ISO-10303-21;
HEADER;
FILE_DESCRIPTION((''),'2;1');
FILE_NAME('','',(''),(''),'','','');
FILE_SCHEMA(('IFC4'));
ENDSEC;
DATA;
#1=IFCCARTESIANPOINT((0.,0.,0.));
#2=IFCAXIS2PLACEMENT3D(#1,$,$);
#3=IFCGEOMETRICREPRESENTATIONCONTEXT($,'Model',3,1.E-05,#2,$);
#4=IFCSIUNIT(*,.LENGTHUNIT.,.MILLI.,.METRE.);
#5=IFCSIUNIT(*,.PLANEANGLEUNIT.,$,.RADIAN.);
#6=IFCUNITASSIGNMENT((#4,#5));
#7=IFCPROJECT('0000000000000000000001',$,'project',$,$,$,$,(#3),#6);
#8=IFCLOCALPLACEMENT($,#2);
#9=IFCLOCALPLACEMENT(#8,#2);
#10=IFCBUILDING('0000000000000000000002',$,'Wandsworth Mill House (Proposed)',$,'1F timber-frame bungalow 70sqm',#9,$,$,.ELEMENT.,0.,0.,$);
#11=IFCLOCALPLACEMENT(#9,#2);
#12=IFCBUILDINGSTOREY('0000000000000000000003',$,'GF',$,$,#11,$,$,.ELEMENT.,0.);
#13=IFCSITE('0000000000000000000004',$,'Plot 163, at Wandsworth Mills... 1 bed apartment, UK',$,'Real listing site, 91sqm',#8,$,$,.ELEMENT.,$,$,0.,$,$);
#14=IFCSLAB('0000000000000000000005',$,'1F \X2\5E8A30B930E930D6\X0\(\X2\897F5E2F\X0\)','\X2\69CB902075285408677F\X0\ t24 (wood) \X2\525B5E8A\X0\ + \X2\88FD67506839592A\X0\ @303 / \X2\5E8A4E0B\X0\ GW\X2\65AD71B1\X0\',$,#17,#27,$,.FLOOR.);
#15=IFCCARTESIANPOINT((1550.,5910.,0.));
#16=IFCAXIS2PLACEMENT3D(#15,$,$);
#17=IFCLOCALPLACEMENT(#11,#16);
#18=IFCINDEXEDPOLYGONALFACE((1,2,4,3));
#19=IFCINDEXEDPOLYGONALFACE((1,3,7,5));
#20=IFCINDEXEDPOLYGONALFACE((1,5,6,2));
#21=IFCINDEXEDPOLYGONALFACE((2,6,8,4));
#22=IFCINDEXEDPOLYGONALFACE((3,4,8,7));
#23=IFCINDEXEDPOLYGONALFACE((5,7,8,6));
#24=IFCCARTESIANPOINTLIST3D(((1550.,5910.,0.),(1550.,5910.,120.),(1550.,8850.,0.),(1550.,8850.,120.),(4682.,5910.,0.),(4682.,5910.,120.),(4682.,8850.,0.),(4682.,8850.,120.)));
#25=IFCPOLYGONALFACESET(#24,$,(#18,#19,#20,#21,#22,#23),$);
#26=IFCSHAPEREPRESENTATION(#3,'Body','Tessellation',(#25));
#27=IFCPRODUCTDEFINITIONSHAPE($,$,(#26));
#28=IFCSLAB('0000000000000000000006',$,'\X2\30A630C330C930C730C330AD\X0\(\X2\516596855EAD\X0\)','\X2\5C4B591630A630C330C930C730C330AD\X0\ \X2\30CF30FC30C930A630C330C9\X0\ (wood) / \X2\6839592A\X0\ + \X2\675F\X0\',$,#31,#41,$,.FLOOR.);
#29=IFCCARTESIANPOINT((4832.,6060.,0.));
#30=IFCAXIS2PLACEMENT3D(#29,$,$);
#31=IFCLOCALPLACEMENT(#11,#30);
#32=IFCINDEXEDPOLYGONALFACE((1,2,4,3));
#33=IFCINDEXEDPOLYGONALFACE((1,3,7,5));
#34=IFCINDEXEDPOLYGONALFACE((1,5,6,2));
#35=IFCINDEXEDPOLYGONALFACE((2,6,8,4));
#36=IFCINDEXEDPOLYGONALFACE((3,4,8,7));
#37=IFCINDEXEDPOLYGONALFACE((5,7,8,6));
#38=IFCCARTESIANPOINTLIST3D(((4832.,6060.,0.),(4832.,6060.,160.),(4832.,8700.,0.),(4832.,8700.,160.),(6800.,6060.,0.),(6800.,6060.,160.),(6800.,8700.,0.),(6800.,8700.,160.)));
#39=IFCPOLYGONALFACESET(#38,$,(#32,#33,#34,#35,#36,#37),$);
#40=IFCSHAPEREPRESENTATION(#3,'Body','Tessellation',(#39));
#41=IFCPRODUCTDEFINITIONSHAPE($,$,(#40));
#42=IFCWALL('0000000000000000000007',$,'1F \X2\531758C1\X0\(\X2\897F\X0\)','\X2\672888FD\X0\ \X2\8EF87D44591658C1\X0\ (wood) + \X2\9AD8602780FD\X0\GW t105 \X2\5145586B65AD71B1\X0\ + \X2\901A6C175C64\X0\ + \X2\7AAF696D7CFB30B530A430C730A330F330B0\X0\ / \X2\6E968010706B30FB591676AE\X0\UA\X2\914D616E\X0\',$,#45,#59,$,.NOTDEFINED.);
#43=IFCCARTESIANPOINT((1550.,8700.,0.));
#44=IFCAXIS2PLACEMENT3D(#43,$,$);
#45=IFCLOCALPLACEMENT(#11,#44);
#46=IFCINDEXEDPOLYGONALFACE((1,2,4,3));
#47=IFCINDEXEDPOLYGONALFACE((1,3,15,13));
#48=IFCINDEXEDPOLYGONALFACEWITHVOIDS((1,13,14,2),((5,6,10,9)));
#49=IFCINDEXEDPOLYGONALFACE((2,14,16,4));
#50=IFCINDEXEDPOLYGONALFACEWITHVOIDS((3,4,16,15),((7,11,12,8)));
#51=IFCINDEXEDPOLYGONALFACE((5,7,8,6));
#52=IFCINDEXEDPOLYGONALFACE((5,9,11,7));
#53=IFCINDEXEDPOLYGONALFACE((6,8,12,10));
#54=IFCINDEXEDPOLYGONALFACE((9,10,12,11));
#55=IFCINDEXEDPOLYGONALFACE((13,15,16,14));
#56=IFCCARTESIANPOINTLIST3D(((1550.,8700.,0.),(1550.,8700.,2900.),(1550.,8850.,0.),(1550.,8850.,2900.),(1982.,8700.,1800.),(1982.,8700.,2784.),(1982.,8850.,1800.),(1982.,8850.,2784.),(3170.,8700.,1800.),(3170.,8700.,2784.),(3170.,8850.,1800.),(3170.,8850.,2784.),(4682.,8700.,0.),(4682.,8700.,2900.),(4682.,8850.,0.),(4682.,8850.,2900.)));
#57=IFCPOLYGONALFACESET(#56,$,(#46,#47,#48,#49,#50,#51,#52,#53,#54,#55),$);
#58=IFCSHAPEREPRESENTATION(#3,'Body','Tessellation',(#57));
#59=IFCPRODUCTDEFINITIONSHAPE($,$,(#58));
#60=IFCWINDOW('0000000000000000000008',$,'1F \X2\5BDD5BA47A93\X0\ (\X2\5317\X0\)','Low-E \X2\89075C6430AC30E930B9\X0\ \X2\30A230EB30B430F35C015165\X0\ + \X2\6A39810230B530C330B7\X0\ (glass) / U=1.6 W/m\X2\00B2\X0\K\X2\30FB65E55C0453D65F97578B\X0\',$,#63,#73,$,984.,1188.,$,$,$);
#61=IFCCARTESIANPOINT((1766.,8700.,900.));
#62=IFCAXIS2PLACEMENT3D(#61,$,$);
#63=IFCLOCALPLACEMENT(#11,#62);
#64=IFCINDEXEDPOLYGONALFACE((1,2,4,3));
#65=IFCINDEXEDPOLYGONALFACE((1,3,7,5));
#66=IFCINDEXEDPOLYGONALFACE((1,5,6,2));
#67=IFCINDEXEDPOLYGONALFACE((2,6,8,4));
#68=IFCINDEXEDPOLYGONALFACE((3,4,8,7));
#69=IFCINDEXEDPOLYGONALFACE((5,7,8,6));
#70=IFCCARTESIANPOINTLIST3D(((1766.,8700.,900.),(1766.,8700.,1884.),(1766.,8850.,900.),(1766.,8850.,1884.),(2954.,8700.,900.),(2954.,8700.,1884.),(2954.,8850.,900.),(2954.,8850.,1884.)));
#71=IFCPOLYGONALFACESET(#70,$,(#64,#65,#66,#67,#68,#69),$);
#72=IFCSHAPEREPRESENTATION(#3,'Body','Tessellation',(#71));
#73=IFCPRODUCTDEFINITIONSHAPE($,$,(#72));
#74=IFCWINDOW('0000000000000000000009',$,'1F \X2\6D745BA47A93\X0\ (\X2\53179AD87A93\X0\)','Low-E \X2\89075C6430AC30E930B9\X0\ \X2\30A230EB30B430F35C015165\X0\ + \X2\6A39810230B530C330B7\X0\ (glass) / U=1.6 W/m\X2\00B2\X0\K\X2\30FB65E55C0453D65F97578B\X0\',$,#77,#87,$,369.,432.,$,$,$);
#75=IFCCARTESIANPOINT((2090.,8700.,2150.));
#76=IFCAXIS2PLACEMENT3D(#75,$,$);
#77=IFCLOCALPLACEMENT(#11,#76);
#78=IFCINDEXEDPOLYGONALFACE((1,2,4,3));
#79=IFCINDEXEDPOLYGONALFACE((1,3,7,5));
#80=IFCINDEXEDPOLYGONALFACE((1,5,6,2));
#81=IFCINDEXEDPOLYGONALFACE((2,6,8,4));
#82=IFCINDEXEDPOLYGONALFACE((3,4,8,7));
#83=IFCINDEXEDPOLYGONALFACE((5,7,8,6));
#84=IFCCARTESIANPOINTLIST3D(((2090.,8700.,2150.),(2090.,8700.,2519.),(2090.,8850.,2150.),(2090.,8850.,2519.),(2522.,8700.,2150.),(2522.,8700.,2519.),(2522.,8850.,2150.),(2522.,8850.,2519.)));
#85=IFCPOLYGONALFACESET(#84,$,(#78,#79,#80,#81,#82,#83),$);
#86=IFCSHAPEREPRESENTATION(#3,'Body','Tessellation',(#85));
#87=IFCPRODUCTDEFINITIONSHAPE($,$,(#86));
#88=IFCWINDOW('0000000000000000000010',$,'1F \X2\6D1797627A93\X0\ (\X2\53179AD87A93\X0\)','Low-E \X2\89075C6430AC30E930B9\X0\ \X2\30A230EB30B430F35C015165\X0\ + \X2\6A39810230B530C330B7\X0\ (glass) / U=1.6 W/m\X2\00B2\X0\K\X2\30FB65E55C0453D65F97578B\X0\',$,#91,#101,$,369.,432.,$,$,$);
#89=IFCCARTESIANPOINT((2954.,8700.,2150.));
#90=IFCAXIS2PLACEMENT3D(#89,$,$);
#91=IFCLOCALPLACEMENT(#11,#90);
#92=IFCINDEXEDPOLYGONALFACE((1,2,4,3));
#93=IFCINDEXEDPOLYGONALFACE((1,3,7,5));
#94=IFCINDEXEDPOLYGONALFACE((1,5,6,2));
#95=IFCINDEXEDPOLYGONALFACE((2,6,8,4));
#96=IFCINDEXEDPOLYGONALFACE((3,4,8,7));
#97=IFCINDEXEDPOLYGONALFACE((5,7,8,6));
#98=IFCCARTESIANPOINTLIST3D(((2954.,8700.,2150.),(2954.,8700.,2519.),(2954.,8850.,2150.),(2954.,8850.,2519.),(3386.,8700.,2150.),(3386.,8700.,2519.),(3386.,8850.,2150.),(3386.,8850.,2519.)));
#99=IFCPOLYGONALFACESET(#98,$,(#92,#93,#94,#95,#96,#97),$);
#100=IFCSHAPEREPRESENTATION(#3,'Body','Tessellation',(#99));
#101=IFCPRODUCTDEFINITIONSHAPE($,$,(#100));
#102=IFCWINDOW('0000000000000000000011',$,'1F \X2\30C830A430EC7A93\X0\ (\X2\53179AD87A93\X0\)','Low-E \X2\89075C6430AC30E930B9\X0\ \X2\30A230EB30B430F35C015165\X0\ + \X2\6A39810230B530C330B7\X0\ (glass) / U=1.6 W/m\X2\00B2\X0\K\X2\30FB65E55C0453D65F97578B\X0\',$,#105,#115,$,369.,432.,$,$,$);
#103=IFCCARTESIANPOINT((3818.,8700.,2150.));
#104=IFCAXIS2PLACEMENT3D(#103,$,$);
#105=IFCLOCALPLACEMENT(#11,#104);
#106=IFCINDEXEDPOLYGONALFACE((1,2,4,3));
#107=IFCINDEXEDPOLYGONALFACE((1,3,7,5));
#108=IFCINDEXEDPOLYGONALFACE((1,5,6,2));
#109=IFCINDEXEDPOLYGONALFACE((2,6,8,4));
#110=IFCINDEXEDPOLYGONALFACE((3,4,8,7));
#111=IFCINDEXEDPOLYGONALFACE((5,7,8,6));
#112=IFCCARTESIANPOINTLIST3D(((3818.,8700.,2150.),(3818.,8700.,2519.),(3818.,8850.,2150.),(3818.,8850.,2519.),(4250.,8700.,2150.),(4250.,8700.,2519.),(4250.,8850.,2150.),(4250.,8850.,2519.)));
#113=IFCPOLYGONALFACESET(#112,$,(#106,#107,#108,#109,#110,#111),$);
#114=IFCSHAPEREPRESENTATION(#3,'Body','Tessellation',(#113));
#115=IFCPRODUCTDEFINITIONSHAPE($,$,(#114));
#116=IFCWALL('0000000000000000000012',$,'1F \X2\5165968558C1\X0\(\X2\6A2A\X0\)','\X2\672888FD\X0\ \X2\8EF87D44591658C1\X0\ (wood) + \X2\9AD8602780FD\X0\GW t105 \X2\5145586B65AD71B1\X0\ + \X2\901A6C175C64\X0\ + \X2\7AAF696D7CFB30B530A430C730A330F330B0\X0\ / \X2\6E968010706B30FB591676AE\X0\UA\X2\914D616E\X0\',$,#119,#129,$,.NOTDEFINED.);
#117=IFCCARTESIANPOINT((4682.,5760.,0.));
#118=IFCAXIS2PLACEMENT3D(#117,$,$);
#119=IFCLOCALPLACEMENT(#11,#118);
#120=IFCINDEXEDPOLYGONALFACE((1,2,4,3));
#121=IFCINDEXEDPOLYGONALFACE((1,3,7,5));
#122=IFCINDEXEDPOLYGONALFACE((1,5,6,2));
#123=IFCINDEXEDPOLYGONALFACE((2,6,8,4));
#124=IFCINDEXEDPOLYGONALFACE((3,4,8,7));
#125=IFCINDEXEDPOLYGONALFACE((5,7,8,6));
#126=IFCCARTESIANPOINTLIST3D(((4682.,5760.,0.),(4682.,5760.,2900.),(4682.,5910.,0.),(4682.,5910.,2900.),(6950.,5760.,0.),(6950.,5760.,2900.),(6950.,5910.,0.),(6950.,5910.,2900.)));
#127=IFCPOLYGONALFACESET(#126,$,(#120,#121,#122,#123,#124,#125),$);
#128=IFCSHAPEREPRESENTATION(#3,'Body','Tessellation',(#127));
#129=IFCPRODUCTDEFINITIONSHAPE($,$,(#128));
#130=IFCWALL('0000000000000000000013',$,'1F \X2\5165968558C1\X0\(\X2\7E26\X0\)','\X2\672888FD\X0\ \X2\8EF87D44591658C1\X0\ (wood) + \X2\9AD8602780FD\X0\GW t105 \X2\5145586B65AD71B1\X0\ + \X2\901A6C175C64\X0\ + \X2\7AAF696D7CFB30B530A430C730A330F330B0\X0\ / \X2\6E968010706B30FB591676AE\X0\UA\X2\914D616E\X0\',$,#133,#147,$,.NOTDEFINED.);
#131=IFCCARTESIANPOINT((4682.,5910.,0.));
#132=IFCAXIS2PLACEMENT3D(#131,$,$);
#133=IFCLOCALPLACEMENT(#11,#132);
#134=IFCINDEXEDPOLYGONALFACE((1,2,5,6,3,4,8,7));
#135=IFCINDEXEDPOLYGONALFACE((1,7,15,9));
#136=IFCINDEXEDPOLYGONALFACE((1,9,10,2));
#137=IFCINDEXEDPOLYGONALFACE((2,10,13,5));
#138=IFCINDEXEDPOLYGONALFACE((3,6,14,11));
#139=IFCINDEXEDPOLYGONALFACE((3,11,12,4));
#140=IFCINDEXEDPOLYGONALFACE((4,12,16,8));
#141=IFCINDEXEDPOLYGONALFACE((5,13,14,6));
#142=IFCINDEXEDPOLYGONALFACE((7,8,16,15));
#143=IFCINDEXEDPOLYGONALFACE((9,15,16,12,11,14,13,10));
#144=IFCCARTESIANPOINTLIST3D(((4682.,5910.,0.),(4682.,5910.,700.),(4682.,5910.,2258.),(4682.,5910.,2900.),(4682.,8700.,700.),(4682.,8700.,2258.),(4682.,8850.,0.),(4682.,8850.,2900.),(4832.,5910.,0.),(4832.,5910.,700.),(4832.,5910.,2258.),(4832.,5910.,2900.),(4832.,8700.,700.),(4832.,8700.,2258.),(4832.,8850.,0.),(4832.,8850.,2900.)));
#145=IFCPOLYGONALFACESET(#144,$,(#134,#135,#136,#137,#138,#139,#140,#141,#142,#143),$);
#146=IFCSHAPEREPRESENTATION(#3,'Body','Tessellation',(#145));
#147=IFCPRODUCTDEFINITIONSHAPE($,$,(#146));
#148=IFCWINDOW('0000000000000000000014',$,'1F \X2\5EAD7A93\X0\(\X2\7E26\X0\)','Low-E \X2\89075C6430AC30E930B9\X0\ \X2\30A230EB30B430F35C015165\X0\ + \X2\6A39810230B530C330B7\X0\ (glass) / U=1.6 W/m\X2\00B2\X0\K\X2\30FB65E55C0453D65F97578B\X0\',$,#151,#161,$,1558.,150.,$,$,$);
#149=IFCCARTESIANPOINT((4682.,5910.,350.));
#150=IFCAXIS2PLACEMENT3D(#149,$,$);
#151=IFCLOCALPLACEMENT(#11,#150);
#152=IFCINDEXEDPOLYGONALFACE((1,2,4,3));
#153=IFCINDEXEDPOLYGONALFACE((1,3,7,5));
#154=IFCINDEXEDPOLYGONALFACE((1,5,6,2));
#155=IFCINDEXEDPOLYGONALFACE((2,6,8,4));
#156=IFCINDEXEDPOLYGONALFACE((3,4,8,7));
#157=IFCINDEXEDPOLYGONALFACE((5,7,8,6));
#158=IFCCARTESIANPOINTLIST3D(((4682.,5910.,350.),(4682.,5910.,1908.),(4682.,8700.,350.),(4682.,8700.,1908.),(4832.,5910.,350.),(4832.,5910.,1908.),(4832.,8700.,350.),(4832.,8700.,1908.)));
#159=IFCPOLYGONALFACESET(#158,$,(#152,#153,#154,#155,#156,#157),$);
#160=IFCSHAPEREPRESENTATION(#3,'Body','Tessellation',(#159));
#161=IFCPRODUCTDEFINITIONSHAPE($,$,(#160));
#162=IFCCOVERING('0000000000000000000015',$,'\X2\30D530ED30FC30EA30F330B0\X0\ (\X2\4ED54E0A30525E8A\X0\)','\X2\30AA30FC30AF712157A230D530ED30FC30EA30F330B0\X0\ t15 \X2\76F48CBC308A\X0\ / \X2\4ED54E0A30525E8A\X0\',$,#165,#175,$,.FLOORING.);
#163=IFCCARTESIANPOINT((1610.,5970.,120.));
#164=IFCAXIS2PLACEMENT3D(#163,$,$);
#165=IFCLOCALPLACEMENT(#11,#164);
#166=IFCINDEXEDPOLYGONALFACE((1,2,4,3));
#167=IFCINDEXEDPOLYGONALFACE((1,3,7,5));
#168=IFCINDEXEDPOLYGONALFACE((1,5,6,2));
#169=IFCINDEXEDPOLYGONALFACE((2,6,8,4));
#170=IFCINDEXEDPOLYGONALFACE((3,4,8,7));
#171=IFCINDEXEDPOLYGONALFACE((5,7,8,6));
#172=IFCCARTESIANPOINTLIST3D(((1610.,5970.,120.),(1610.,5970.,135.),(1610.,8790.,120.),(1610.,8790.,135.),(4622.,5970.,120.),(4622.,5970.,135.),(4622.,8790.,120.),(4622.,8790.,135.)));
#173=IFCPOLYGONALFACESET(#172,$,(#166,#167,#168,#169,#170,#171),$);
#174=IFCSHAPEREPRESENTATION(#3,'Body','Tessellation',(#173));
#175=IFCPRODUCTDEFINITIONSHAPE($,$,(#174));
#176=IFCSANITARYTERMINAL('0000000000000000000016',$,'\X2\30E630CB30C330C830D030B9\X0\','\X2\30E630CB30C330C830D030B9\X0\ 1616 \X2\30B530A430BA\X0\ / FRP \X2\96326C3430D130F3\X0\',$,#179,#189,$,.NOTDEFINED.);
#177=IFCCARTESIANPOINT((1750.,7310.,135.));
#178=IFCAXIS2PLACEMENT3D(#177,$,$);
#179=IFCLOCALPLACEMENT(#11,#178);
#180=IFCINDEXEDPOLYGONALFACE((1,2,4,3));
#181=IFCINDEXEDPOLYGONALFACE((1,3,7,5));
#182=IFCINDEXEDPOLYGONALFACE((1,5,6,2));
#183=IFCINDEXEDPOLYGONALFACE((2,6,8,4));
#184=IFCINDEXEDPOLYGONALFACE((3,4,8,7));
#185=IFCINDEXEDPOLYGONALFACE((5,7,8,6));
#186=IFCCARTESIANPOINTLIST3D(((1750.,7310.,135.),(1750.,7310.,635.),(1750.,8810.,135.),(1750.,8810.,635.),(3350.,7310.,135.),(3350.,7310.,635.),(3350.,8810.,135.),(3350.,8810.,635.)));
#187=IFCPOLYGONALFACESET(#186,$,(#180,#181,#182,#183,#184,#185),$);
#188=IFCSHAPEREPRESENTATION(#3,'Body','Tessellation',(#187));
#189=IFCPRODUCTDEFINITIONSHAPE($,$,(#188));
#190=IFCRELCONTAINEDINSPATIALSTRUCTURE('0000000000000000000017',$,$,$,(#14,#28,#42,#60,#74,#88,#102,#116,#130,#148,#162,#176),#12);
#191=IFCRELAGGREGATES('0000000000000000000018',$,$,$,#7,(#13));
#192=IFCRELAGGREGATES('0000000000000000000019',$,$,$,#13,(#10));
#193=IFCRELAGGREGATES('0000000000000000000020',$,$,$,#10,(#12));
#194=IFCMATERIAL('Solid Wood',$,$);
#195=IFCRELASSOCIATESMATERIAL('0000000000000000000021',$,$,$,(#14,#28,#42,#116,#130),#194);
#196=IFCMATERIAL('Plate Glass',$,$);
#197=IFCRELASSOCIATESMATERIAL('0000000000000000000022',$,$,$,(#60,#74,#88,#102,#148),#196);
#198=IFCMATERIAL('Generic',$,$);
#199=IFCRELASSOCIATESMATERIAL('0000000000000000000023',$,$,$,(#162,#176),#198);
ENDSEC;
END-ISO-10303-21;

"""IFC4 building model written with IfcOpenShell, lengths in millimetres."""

from ifc_helpers import new_model, si_unit, frame, frame_2d, origin, place, context, project, spatial, rectangle, extrude, material, element, fill, save


model = new_model("IFC4")

# Units and contexts
model_context = context("Model", 3, precision=1e-05, world=origin())
ifc_project = project(units=[si_unit("LENGTHUNIT", "METRE", prefix="MILLI"), si_unit("PLANEANGLEUNIT", "RADIAN")], contexts=[model_context])

# Site, building, storey
site_placement = place(None, origin())
site = spatial("IfcSite", under=ifc_project, at=site_placement, Name="Plot 163, at Wandsworth Mills... 1 bed apartment, UK", ObjectType="Real listing site, 91sqm", CompositionType="ELEMENT", RefElevation=0.0)
building_placement = place(site_placement, origin())
building = spatial("IfcBuilding", under=site, at=building_placement, Name="Wandsworth Mill House (Proposed)", ObjectType="1F timber-frame bungalow 70sqm", CompositionType="ELEMENT", ElevationOfRefHeight=0.0, ElevationOfTerrain=0.0)
storey_placement = place(building_placement, origin())
storey = spatial("IfcBuildingStorey", under=building, at=storey_placement, Name="GF", CompositionType="ELEMENT", Elevation=0.0)

# Slabs
ifc_material_1 = material(Name="Solid Wood")
slab_1_placement = place(storey_placement, frame((1550.0, 5910.0, 0.0)))
element("IfcSlab", 1, at=slab_1_placement, inside=storey, material=ifc_material_1, Name="1F 床スラブ(西帯)", Description="構造用合板 t24 (wood) 剛床 + 製材根太 @303 / 床下 GW断熱", PredefinedType="FLOOR", context=model_context, shape_type="SweptSolid", body=[
    extrude(rectangle(XDim=3132.0, YDim=2940.0, at=frame_2d((1566.0, 1470.0))), frame((1550.0, 5910.0, 0.0)), (0.0, 0.0, 1.0), 120.0),
])
slab_2_placement = place(storey_placement, frame((4832.0, 6060.0, 0.0)))
element("IfcSlab", 2, at=slab_2_placement, inside=storey, material=ifc_material_1, Name="ウッドデッキ(入隅庭)", Description="屋外ウッドデッキ ハードウッド (wood) / 根太 + 束", PredefinedType="FLOOR", context=model_context, shape_type="SweptSolid", body=[
    extrude(rectangle(XDim=1968.0, YDim=2640.0, at=frame_2d((984.0, 1320.0))), frame((4832.0, 6060.0, 0.0)), (0.0, 0.0, 1.0), 160.0),
])

# Wall, openings, windows
wall_1_placement = place(storey_placement, frame((1550.0, 8700.0, 0.0)))
wall_1 = element("IfcWall", 3, at=wall_1_placement, inside=storey, material=ifc_material_1, Name="1F 北壁(西)", Description="木製 軸組外壁 (wood) + 高性能GW t105 充填断熱 + 通気層 + 窯業系サイディング / 準耐火・外皮UA配慮", PredefinedType="NOTDEFINED", context=model_context, shape_type="SweptSolid", body=[
    extrude(rectangle(XDim=3132.0, YDim=150.0, at=frame_2d((1566.0, 75.0))), frame((1550.0, 8700.0, 0.0)), (0.0, 0.0, 1.0), 2900.0),
])
opening_1_placement = place(storey_placement, frame((1766.0, 8700.0, 900.0)))
opening_1 = element("IfcOpeningElement", 4, at=opening_1_placement, cuts=wall_1, PredefinedType="NOTDEFINED", context=model_context, shape_type="SweptSolid", body=[
    extrude(rectangle(XDim=1188.0, YDim=150.0, at=frame_2d((594.0, 75.0))), frame((1766.0, 8700.0, 900.0)), (0.0, 0.0, 1.0), 984.0),
])
opening_2_placement = place(storey_placement, frame((2090.0, 8700.0, 2150.0)))
opening_2 = element("IfcOpeningElement", 5, at=opening_2_placement, cuts=wall_1, PredefinedType="NOTDEFINED", context=model_context, shape_type="SweptSolid", body=[
    extrude(rectangle(XDim=432.0, YDim=150.0, at=frame_2d((216.0, 75.0))), frame((2090.0, 8700.0, 2150.0)), (0.0, 0.0, 1.0), 369.0),
])
opening_3_placement = place(storey_placement, frame((2954.0, 8700.0, 2150.0)))
opening_3 = element("IfcOpeningElement", 6, at=opening_3_placement, cuts=wall_1, PredefinedType="NOTDEFINED", context=model_context, shape_type="SweptSolid", body=[
    extrude(rectangle(XDim=432.0, YDim=150.0, at=frame_2d((216.0, 75.0))), frame((2954.0, 8700.0, 2150.0)), (0.0, 0.0, 1.0), 369.0),
])
opening_4_placement = place(storey_placement, frame((3818.0, 8700.0, 2150.0)))
opening_4 = element("IfcOpeningElement", 7, at=opening_4_placement, cuts=wall_1, PredefinedType="NOTDEFINED", context=model_context, shape_type="SweptSolid", body=[
    extrude(rectangle(XDim=432.0, YDim=150.0, at=frame_2d((216.0, 75.0))), frame((3818.0, 8700.0, 2150.0)), (0.0, 0.0, 1.0), 369.0),
])
ifc_material_2 = material(Name="Plate Glass")
window_1_placement = place(storey_placement, frame((1766.0, 8700.0, 900.0)))
window_1 = element("IfcWindow", 8, at=window_1_placement, inside=storey, material=ifc_material_2, Name="1F 寝室窓 (北)", Description="Low-E 複層ガラス アルゴン封入 + 樹脂サッシ (glass) / U=1.6 W/m²K・日射取得型", OverallHeight=984.0, OverallWidth=1188.0, context=model_context, shape_type="SweptSolid", body=[
    extrude(rectangle(XDim=1188.0, YDim=150.0, at=frame_2d((594.0, 75.0))), frame((1766.0, 8700.0, 900.0)), (0.0, 0.0, 1.0), 984.0),
])
fill(opening_1, window_1)
window_2_placement = place(storey_placement, frame((2090.0, 8700.0, 2150.0)))
window_2 = element("IfcWindow", 9, at=window_2_placement, inside=storey, material=ifc_material_2, Name="1F 浴室窓 (北高窓)", Description="Low-E 複層ガラス アルゴン封入 + 樹脂サッシ (glass) / U=1.6 W/m²K・日射取得型", OverallHeight=369.0, OverallWidth=432.0, context=model_context, shape_type="SweptSolid", body=[
    extrude(rectangle(XDim=432.0, YDim=150.0, at=frame_2d((216.0, 75.0))), frame((2090.0, 8700.0, 2150.0)), (0.0, 0.0, 1.0), 369.0),
])
fill(opening_2, window_2)
window_3_placement = place(storey_placement, frame((2954.0, 8700.0, 2150.0)))
window_3 = element("IfcWindow", 10, at=window_3_placement, inside=storey, material=ifc_material_2, Name="1F 洗面窓 (北高窓)", Description="Low-E 複層ガラス アルゴン封入 + 樹脂サッシ (glass) / U=1.6 W/m²K・日射取得型", OverallHeight=369.0, OverallWidth=432.0, context=model_context, shape_type="SweptSolid", body=[
    extrude(rectangle(XDim=432.0, YDim=150.0, at=frame_2d((216.0, 75.0))), frame((2954.0, 8700.0, 2150.0)), (0.0, 0.0, 1.0), 369.0),
])
fill(opening_3, window_3)
window_4_placement = place(storey_placement, frame((3818.0, 8700.0, 2150.0)))
window_4 = element("IfcWindow", 11, at=window_4_placement, inside=storey, material=ifc_material_2, Name="1F トイレ窓 (北高窓)", Description="Low-E 複層ガラス アルゴン封入 + 樹脂サッシ (glass) / U=1.6 W/m²K・日射取得型", OverallHeight=369.0, OverallWidth=432.0, context=model_context, shape_type="SweptSolid", body=[
    extrude(rectangle(XDim=432.0, YDim=150.0, at=frame_2d((216.0, 75.0))), frame((3818.0, 8700.0, 2150.0)), (0.0, 0.0, 1.0), 369.0),
])
fill(opening_4, window_4)

# Wall
wall_2_placement = place(storey_placement, frame((4682.0, 5760.0, 0.0)))
element("IfcWall", 12, at=wall_2_placement, inside=storey, material=ifc_material_1, Name="1F 入隅壁(横)", Description="木製 軸組外壁 (wood) + 高性能GW t105 充填断熱 + 通気層 + 窯業系サイディング / 準耐火・外皮UA配慮", PredefinedType="NOTDEFINED", context=model_context, shape_type="SweptSolid", body=[
    extrude(rectangle(XDim=2268.0, YDim=150.0, at=frame_2d((1134.0, 75.0))), frame((4682.0, 5760.0, 0.0)), (0.0, 0.0, 1.0), 2900.0),
])

# Wall, opening, window
wall_3_placement = place(storey_placement, frame((4682.0, 5910.0, 0.0)))
wall_3 = element("IfcWall", 13, at=wall_3_placement, inside=storey, material=ifc_material_1, Name="1F 入隅壁(縦)", Description="木製 軸組外壁 (wood) + 高性能GW t105 充填断熱 + 通気層 + 窯業系サイディング / 準耐火・外皮UA配慮", PredefinedType="NOTDEFINED", context=model_context, shape_type="SweptSolid", body=[
    extrude(rectangle(XDim=150.0, YDim=2940.0, at=frame_2d((75.0, 1470.0))), frame((4682.0, 5910.0, 0.0)), (0.0, 0.0, 1.0), 2900.0),
])
opening_5_placement = place(storey_placement, frame((4682.0, 5910.0, 350.0)))
opening_5 = element("IfcOpeningElement", 14, at=opening_5_placement, cuts=wall_3, PredefinedType="NOTDEFINED", context=model_context, shape_type="SweptSolid", body=[
    extrude(rectangle(XDim=150.0, YDim=2790.0, at=frame_2d((75.0, 1395.0))), frame((4682.0, 5910.0, 350.0)), (0.0, 0.0, 1.0), 1558.0),
])
window_5_placement = place(storey_placement, frame((4682.0, 5910.0, 350.0)))
window_5 = element("IfcWindow", 15, at=window_5_placement, inside=storey, material=ifc_material_2, Name="1F 庭窓(縦)", Description="Low-E 複層ガラス アルゴン封入 + 樹脂サッシ (glass) / U=1.6 W/m²K・日射取得型", OverallHeight=1558.0, OverallWidth=150.0, context=model_context, shape_type="SweptSolid", body=[
    extrude(rectangle(XDim=150.0, YDim=2790.0, at=frame_2d((75.0, 1395.0))), frame((4682.0, 5910.0, 350.0)), (0.0, 0.0, 1.0), 1558.0),
])
fill(opening_5, window_5)

# Covering
ifc_material_3 = material(Name="Generic")
covering_placement = place(storey_placement, frame((1610.0, 5970.0, 120.0)))
element("IfcCovering", 16, at=covering_placement, inside=storey, material=ifc_material_3, Name="フローリング (仕上げ床)", Description="オーク無垢フローリング t15 直貼り / 仕上げ床", PredefinedType="FLOORING", context=model_context, shape_type="SweptSolid", body=[
    extrude(rectangle(XDim=3012.0, YDim=2820.0, at=frame_2d((1506.0, 1410.0))), frame((1610.0, 5970.0, 120.0)), (0.0, 0.0, 1.0), 15.0),
])

# Sanitary terminal
sanitary_terminal_1_placement = place(storey_placement, frame((1750.0, 7310.0, 135.0)))
element("IfcSanitaryTerminal", 17, at=sanitary_terminal_1_placement, inside=storey, material=ifc_material_3, Name="ユニットバス", Description="ユニットバス 1616 サイズ / FRP 防水パン", PredefinedType="NOTDEFINED", context=model_context, shape_type="SweptSolid", body=[
    extrude(rectangle(XDim=1600.0, YDim=1500.0, at=frame_2d((800.0, 750.0))), frame((1750.0, 7310.0, 135.0)), (0.0, 0.0, 1.0), 500.0),
])

save(model, "model.ifc")
